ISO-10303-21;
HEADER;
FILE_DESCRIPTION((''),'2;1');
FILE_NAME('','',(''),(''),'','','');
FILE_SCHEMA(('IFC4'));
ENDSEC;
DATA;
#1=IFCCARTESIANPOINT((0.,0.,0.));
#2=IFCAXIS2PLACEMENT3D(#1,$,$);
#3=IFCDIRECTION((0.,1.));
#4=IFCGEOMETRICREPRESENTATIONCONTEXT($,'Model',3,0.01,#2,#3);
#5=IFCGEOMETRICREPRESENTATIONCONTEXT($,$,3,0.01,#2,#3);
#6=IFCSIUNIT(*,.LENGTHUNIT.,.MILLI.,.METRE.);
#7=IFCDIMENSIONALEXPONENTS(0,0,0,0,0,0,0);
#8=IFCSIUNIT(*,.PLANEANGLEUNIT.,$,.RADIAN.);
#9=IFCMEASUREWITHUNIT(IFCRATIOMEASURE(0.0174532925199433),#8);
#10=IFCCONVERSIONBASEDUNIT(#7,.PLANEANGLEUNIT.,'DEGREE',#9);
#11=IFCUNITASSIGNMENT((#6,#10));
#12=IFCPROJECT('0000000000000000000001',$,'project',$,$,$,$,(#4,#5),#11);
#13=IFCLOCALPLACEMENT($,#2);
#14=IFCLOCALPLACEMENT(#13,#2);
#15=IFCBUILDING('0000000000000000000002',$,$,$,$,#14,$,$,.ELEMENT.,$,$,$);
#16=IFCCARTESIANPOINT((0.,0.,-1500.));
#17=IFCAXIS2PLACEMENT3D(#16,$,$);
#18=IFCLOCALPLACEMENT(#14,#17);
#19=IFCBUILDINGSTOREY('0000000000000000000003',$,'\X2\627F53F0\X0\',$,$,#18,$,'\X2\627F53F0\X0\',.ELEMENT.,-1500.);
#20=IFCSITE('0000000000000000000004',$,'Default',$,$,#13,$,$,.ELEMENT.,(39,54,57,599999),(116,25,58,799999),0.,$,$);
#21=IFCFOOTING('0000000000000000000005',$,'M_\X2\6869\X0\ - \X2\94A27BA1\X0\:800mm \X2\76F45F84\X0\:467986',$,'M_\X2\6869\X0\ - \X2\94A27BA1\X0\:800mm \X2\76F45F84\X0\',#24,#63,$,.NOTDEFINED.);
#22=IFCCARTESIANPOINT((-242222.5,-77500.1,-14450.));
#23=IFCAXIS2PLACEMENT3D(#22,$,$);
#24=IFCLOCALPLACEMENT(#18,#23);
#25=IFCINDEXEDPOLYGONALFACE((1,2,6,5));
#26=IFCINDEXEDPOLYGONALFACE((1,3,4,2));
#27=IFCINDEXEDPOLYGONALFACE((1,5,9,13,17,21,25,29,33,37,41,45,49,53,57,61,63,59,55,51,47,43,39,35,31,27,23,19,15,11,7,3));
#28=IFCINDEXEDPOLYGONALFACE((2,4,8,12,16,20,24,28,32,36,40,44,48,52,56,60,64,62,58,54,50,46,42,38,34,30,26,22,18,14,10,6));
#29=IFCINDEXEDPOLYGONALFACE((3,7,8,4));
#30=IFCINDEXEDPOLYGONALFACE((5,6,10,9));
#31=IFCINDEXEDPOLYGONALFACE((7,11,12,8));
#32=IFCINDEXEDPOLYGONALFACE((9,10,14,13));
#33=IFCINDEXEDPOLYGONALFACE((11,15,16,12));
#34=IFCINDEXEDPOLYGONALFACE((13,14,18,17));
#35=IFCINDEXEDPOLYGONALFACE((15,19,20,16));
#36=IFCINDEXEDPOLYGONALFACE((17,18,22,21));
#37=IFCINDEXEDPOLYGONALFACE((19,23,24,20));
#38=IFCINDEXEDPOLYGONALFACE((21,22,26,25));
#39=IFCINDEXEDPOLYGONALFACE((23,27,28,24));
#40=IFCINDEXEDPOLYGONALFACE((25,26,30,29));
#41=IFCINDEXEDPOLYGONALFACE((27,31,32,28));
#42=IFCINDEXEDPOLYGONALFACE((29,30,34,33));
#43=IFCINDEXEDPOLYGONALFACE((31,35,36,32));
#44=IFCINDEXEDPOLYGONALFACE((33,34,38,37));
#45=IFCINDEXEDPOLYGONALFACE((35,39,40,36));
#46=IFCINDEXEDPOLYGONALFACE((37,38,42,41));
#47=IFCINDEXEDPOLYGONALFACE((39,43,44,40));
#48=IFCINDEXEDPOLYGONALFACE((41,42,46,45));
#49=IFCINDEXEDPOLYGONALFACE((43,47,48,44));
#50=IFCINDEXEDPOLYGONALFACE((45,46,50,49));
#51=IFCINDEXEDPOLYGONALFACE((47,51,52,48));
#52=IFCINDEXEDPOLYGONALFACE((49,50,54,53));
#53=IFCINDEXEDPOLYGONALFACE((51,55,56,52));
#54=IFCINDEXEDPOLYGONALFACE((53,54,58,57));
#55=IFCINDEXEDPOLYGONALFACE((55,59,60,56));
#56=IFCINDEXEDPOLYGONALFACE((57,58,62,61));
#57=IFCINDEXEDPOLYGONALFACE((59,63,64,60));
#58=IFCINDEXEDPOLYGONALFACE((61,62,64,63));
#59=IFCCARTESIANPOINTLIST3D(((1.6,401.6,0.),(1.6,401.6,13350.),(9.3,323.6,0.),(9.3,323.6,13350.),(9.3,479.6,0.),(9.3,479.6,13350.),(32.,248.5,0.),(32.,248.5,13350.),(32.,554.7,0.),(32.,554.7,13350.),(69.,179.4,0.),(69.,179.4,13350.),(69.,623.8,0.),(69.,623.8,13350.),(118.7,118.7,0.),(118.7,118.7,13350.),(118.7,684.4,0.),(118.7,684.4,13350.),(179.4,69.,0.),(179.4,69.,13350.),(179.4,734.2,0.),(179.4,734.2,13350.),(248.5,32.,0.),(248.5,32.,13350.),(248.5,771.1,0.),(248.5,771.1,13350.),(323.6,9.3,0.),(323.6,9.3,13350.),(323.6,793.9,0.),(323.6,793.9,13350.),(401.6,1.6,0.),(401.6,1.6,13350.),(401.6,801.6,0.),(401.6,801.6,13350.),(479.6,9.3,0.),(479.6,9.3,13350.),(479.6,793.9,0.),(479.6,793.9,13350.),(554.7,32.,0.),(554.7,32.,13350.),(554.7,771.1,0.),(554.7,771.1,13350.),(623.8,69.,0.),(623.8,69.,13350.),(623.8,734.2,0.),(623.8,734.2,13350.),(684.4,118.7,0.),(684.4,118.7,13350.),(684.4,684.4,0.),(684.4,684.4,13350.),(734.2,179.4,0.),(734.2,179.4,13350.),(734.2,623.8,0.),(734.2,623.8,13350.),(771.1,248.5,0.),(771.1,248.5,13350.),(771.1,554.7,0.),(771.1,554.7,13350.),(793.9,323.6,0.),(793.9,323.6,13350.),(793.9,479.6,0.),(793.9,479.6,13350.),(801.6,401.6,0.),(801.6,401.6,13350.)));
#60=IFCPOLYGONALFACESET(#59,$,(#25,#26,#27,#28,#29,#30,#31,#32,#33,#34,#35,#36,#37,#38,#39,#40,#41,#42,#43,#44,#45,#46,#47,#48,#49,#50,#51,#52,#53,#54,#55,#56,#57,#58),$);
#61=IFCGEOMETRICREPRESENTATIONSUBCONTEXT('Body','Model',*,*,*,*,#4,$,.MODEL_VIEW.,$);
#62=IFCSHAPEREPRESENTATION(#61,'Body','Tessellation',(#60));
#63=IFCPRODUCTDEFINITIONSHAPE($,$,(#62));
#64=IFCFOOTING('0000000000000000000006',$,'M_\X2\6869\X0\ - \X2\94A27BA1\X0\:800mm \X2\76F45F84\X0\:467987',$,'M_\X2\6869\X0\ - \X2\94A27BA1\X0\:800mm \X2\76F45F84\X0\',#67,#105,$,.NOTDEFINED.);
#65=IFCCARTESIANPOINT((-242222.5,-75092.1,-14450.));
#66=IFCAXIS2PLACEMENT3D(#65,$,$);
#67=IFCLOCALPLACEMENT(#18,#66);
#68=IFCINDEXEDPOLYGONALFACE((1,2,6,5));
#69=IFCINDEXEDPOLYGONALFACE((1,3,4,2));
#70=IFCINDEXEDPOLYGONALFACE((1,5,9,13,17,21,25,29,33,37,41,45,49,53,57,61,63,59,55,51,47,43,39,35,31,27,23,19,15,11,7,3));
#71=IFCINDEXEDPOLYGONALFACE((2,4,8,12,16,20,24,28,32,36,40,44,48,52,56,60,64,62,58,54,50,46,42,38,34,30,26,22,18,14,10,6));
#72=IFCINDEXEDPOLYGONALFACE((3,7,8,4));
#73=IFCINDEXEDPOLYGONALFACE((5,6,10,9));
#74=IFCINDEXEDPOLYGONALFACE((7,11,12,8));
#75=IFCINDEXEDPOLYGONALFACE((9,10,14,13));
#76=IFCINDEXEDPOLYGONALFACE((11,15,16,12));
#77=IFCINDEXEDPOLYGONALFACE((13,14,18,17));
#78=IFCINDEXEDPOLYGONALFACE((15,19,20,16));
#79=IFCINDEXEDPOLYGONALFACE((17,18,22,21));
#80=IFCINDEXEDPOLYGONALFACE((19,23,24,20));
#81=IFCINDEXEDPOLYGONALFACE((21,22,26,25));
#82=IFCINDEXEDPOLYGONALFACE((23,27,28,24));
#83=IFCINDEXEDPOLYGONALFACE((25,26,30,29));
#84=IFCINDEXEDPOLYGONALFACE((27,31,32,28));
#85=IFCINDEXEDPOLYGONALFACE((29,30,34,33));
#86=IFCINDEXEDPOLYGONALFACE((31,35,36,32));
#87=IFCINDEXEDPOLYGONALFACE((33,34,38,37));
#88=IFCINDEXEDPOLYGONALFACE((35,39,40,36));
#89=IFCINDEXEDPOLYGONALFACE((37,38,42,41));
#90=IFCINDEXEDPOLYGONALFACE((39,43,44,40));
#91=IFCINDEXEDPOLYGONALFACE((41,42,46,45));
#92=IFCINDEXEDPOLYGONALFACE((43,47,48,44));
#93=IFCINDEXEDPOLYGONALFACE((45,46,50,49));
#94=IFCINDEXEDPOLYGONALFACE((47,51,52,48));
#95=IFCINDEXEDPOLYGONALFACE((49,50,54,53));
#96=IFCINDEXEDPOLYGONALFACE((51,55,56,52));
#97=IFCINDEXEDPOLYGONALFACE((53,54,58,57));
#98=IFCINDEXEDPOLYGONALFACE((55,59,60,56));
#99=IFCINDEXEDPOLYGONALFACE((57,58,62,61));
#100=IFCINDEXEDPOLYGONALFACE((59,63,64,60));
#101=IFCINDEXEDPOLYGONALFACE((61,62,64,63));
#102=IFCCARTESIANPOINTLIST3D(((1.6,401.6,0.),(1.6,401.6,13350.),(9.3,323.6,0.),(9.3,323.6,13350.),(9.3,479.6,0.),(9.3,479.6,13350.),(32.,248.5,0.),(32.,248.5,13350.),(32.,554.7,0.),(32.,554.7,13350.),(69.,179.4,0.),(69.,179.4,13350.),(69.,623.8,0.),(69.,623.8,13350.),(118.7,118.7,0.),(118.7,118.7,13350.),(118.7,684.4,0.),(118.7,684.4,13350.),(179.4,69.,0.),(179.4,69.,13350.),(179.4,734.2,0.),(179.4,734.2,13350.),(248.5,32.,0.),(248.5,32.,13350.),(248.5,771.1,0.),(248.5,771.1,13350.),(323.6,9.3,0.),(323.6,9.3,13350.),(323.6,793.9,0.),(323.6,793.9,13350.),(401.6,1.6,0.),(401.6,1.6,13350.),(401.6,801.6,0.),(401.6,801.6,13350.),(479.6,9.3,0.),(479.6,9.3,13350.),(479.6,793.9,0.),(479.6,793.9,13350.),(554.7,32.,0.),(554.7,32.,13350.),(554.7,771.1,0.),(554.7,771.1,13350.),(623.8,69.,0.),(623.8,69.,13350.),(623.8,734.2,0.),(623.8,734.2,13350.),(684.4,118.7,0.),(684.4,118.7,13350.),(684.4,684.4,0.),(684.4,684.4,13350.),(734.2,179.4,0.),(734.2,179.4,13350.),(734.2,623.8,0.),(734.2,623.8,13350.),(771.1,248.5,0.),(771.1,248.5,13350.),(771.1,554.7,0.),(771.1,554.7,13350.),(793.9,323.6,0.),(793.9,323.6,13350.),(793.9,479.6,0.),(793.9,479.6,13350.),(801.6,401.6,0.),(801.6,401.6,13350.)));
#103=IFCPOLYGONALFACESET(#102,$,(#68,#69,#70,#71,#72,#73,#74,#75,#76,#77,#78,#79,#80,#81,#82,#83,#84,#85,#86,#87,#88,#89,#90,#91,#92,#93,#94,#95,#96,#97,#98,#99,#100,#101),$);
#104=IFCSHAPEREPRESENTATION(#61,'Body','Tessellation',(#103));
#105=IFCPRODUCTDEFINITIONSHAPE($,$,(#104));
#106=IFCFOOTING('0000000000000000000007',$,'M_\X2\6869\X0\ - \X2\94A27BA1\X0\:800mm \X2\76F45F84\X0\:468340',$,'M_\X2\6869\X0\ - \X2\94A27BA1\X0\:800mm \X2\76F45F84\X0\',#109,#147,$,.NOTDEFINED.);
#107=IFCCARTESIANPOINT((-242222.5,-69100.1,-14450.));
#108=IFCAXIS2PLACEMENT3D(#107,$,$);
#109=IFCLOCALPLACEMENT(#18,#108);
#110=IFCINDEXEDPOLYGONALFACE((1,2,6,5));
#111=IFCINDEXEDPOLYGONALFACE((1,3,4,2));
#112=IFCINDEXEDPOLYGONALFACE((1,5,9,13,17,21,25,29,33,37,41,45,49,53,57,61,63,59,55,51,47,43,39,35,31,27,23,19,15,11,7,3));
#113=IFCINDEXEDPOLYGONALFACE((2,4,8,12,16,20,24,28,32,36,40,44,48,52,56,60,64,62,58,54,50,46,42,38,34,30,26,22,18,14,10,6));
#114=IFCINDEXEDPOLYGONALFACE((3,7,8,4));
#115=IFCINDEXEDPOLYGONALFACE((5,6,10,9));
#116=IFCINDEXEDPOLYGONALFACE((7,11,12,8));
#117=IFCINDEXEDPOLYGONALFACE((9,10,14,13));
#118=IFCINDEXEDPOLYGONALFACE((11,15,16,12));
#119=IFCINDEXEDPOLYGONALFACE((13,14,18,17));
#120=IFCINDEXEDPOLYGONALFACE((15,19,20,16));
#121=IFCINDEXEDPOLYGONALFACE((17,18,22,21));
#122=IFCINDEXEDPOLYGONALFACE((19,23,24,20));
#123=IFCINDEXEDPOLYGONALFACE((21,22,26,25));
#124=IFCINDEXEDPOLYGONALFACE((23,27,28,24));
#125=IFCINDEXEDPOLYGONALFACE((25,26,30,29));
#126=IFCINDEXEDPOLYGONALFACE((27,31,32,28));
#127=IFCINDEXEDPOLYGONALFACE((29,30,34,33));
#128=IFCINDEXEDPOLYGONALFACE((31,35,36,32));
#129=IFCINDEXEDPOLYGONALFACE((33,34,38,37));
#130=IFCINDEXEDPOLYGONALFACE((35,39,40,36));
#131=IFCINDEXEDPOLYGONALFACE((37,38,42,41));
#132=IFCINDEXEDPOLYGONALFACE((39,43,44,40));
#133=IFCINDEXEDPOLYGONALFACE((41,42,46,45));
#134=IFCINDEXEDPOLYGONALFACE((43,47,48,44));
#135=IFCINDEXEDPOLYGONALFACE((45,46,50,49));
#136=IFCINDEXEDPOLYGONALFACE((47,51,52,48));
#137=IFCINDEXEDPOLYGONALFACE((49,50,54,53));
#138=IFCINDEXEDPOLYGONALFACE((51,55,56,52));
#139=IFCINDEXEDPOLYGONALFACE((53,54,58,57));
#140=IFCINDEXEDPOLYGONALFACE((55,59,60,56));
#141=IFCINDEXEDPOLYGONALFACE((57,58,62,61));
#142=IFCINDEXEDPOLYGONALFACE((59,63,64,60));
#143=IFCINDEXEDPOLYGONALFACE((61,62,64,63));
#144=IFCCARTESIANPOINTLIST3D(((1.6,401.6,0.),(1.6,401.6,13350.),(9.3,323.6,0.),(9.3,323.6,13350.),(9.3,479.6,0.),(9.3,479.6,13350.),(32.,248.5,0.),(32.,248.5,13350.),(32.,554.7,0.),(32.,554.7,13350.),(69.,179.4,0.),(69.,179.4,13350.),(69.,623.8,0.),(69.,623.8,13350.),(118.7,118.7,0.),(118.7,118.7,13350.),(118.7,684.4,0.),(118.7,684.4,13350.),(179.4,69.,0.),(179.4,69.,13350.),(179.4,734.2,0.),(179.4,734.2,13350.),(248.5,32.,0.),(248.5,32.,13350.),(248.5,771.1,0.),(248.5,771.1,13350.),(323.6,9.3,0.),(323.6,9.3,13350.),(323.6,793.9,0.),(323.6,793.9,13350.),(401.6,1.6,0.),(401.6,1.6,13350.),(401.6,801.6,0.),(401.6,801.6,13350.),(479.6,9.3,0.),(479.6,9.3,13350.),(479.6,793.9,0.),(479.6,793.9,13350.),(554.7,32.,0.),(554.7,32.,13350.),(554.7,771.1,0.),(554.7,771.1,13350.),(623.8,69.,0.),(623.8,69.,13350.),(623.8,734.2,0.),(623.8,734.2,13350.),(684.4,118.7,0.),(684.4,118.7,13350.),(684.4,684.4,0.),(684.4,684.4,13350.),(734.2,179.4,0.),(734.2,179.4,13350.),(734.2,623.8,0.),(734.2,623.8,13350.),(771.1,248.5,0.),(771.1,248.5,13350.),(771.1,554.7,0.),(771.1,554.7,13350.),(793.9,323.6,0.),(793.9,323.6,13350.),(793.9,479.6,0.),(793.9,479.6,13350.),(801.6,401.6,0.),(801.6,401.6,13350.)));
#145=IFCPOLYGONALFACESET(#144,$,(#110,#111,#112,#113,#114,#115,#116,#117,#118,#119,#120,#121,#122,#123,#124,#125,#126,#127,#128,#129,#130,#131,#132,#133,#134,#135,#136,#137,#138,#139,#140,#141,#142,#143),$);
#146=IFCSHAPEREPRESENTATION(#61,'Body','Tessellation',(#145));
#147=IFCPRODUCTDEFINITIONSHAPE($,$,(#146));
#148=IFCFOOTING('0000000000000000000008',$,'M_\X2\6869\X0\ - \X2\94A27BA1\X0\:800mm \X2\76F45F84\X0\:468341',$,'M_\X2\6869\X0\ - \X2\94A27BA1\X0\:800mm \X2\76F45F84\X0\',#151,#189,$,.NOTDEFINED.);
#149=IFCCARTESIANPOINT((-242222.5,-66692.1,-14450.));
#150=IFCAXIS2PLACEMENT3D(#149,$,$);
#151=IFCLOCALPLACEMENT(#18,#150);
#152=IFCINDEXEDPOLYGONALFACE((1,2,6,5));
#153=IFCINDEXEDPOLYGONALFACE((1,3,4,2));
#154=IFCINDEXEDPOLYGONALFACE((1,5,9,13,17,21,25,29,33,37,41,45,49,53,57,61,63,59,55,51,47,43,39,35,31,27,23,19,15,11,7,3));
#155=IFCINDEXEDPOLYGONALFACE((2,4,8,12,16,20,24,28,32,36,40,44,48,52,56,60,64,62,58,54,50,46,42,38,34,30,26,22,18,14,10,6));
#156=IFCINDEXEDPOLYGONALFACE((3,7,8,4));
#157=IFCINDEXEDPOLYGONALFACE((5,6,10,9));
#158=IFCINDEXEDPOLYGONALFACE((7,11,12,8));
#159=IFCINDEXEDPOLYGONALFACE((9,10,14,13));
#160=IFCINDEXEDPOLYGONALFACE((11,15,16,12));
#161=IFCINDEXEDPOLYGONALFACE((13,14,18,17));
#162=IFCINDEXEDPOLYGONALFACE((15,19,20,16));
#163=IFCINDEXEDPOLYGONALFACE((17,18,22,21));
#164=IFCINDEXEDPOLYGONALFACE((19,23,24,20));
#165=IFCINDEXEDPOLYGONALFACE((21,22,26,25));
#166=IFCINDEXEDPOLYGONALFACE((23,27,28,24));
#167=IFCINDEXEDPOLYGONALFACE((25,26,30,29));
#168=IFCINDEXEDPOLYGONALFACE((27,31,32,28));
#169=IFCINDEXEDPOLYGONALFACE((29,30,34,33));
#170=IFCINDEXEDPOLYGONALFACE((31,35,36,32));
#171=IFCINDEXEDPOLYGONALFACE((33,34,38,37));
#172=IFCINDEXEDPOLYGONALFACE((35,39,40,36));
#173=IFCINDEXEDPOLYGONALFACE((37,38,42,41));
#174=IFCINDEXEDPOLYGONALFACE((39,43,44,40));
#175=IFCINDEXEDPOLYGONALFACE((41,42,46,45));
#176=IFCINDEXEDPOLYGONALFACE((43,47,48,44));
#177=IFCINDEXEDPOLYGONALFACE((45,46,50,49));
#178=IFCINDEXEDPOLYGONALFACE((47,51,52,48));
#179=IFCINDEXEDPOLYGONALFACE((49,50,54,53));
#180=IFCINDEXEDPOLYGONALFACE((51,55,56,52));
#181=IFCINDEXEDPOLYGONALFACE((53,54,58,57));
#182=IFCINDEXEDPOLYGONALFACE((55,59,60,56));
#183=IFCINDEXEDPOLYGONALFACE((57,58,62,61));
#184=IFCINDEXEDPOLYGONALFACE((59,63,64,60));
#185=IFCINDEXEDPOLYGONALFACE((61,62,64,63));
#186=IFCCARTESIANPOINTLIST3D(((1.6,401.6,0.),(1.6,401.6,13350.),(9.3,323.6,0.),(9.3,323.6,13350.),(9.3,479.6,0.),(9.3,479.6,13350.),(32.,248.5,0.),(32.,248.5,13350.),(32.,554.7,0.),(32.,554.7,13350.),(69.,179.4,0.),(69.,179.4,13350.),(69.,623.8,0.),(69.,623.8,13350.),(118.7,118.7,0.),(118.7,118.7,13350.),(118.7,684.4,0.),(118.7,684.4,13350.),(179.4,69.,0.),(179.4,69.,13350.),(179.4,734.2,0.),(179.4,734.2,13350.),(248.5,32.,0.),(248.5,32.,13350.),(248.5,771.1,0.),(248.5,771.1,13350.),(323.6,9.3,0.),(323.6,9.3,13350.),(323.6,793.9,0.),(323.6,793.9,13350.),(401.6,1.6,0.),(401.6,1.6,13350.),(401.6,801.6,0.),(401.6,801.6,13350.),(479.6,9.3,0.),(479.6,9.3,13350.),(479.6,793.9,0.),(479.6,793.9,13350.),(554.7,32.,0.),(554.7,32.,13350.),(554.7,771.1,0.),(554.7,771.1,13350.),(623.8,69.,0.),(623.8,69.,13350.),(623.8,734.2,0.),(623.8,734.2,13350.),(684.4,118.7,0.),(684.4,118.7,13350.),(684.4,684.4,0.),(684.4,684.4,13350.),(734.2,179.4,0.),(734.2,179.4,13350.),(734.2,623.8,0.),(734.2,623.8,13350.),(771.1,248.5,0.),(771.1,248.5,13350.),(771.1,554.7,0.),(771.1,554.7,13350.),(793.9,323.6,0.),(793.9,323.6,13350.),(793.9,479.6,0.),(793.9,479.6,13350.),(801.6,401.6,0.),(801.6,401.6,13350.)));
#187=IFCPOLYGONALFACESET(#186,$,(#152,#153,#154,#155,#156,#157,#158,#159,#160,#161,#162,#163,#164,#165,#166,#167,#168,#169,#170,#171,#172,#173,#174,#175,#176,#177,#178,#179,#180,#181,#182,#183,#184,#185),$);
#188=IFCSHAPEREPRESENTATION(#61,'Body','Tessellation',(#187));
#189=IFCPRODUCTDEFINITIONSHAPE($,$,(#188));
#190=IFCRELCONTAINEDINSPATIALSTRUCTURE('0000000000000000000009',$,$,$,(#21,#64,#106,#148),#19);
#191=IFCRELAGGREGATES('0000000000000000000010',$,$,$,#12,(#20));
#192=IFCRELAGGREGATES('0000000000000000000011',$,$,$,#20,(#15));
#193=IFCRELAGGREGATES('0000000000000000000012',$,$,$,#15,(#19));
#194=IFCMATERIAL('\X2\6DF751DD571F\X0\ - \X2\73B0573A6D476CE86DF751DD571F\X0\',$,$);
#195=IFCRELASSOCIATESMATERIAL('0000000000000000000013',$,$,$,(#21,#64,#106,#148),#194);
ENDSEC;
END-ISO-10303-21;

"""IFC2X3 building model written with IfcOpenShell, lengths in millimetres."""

from ifc_helpers import new_model, entity, si_unit, converted_unit, direction, frame, origin, origin_2d_with_axis, place, context, subcontext, project, spatial, circle, extrude, material, element, save


model = new_model("IFC2X3")

# Units and contexts
model_context = context("Model", 3, precision=0.01, world=origin(), true_north=direction((0.0, 1.0)))
context_of_model = context(None, 3, precision=0.01, world=origin(), true_north=direction((0.0, 1.0)))
body_context = subcontext(model_context, "Body", "Model", "MODEL_VIEW")
ifc_project = project(units=[si_unit("LENGTHUNIT", "METRE", prefix="MILLI"), converted_unit("PLANEANGLEUNIT", "DEGREE", entity("IfcRatioMeasure", 0.0174532925199433), si_unit("PLANEANGLEUNIT", "RADIAN"), dimensions=[0, 0, 0, 0, 0, 0, 0])], contexts=[model_context, context_of_model])

# Site, building, storey
site_placement = place(None, origin())
site = spatial("IfcSite", under=ifc_project, at=site_placement, Name="Default", CompositionType="ELEMENT", RefLatitude=(39, 54, 57, 599999), RefLongitude=(116, 25, 58, 799999), RefElevation=0.0)
building_placement = place(site_placement, origin())
building = spatial("IfcBuilding", under=site, at=building_placement, CompositionType="ELEMENT")
storey_placement = place(building_placement, frame((0.0, 0.0, -1500.0)))
storey = spatial("IfcBuildingStorey", under=building, at=storey_placement, Name="承台", LongName="承台", CompositionType="ELEMENT", Elevation=-1500.0)

# Footings
ifc_material_1 = material(Name="混凝土 - 现场浇注混凝土")
for number, where, name in (
    (1, (-242222.5, -77500.1, -14450.0), "M_桩 - 钢管:800mm 直径:467986"),
    (2, (-242222.5, -75092.1, -14450.0), "M_桩 - 钢管:800mm 直径:467987"),
    (3, (-242222.5, -69100.1, -14450.0), "M_桩 - 钢管:800mm 直径:468340"),
    (4, (-242222.5, -66692.1, -14450.0), "M_桩 - 钢管:800mm 直径:468341"),
):
    element("IfcFooting", number, at=place(storey_placement, frame(where)), inside=storey, material=ifc_material_1, Name=name, ObjectType="M_桩 - 钢管:800mm 直径", PredefinedType="NOTDEFINED", context=body_context, shape_type="SweptSolid", body=[
        extrude(circle(Radius=400.0, at=origin_2d_with_axis()), frame((401.6, 401.6, 0.0), z_axis=(0.0, 0.0, 1.0), x_axis=(0.0, 1.0, 0.0)), (0.0, 0.0, 1.0), 13350.0),
    ])

save(model, "model.ifc")
